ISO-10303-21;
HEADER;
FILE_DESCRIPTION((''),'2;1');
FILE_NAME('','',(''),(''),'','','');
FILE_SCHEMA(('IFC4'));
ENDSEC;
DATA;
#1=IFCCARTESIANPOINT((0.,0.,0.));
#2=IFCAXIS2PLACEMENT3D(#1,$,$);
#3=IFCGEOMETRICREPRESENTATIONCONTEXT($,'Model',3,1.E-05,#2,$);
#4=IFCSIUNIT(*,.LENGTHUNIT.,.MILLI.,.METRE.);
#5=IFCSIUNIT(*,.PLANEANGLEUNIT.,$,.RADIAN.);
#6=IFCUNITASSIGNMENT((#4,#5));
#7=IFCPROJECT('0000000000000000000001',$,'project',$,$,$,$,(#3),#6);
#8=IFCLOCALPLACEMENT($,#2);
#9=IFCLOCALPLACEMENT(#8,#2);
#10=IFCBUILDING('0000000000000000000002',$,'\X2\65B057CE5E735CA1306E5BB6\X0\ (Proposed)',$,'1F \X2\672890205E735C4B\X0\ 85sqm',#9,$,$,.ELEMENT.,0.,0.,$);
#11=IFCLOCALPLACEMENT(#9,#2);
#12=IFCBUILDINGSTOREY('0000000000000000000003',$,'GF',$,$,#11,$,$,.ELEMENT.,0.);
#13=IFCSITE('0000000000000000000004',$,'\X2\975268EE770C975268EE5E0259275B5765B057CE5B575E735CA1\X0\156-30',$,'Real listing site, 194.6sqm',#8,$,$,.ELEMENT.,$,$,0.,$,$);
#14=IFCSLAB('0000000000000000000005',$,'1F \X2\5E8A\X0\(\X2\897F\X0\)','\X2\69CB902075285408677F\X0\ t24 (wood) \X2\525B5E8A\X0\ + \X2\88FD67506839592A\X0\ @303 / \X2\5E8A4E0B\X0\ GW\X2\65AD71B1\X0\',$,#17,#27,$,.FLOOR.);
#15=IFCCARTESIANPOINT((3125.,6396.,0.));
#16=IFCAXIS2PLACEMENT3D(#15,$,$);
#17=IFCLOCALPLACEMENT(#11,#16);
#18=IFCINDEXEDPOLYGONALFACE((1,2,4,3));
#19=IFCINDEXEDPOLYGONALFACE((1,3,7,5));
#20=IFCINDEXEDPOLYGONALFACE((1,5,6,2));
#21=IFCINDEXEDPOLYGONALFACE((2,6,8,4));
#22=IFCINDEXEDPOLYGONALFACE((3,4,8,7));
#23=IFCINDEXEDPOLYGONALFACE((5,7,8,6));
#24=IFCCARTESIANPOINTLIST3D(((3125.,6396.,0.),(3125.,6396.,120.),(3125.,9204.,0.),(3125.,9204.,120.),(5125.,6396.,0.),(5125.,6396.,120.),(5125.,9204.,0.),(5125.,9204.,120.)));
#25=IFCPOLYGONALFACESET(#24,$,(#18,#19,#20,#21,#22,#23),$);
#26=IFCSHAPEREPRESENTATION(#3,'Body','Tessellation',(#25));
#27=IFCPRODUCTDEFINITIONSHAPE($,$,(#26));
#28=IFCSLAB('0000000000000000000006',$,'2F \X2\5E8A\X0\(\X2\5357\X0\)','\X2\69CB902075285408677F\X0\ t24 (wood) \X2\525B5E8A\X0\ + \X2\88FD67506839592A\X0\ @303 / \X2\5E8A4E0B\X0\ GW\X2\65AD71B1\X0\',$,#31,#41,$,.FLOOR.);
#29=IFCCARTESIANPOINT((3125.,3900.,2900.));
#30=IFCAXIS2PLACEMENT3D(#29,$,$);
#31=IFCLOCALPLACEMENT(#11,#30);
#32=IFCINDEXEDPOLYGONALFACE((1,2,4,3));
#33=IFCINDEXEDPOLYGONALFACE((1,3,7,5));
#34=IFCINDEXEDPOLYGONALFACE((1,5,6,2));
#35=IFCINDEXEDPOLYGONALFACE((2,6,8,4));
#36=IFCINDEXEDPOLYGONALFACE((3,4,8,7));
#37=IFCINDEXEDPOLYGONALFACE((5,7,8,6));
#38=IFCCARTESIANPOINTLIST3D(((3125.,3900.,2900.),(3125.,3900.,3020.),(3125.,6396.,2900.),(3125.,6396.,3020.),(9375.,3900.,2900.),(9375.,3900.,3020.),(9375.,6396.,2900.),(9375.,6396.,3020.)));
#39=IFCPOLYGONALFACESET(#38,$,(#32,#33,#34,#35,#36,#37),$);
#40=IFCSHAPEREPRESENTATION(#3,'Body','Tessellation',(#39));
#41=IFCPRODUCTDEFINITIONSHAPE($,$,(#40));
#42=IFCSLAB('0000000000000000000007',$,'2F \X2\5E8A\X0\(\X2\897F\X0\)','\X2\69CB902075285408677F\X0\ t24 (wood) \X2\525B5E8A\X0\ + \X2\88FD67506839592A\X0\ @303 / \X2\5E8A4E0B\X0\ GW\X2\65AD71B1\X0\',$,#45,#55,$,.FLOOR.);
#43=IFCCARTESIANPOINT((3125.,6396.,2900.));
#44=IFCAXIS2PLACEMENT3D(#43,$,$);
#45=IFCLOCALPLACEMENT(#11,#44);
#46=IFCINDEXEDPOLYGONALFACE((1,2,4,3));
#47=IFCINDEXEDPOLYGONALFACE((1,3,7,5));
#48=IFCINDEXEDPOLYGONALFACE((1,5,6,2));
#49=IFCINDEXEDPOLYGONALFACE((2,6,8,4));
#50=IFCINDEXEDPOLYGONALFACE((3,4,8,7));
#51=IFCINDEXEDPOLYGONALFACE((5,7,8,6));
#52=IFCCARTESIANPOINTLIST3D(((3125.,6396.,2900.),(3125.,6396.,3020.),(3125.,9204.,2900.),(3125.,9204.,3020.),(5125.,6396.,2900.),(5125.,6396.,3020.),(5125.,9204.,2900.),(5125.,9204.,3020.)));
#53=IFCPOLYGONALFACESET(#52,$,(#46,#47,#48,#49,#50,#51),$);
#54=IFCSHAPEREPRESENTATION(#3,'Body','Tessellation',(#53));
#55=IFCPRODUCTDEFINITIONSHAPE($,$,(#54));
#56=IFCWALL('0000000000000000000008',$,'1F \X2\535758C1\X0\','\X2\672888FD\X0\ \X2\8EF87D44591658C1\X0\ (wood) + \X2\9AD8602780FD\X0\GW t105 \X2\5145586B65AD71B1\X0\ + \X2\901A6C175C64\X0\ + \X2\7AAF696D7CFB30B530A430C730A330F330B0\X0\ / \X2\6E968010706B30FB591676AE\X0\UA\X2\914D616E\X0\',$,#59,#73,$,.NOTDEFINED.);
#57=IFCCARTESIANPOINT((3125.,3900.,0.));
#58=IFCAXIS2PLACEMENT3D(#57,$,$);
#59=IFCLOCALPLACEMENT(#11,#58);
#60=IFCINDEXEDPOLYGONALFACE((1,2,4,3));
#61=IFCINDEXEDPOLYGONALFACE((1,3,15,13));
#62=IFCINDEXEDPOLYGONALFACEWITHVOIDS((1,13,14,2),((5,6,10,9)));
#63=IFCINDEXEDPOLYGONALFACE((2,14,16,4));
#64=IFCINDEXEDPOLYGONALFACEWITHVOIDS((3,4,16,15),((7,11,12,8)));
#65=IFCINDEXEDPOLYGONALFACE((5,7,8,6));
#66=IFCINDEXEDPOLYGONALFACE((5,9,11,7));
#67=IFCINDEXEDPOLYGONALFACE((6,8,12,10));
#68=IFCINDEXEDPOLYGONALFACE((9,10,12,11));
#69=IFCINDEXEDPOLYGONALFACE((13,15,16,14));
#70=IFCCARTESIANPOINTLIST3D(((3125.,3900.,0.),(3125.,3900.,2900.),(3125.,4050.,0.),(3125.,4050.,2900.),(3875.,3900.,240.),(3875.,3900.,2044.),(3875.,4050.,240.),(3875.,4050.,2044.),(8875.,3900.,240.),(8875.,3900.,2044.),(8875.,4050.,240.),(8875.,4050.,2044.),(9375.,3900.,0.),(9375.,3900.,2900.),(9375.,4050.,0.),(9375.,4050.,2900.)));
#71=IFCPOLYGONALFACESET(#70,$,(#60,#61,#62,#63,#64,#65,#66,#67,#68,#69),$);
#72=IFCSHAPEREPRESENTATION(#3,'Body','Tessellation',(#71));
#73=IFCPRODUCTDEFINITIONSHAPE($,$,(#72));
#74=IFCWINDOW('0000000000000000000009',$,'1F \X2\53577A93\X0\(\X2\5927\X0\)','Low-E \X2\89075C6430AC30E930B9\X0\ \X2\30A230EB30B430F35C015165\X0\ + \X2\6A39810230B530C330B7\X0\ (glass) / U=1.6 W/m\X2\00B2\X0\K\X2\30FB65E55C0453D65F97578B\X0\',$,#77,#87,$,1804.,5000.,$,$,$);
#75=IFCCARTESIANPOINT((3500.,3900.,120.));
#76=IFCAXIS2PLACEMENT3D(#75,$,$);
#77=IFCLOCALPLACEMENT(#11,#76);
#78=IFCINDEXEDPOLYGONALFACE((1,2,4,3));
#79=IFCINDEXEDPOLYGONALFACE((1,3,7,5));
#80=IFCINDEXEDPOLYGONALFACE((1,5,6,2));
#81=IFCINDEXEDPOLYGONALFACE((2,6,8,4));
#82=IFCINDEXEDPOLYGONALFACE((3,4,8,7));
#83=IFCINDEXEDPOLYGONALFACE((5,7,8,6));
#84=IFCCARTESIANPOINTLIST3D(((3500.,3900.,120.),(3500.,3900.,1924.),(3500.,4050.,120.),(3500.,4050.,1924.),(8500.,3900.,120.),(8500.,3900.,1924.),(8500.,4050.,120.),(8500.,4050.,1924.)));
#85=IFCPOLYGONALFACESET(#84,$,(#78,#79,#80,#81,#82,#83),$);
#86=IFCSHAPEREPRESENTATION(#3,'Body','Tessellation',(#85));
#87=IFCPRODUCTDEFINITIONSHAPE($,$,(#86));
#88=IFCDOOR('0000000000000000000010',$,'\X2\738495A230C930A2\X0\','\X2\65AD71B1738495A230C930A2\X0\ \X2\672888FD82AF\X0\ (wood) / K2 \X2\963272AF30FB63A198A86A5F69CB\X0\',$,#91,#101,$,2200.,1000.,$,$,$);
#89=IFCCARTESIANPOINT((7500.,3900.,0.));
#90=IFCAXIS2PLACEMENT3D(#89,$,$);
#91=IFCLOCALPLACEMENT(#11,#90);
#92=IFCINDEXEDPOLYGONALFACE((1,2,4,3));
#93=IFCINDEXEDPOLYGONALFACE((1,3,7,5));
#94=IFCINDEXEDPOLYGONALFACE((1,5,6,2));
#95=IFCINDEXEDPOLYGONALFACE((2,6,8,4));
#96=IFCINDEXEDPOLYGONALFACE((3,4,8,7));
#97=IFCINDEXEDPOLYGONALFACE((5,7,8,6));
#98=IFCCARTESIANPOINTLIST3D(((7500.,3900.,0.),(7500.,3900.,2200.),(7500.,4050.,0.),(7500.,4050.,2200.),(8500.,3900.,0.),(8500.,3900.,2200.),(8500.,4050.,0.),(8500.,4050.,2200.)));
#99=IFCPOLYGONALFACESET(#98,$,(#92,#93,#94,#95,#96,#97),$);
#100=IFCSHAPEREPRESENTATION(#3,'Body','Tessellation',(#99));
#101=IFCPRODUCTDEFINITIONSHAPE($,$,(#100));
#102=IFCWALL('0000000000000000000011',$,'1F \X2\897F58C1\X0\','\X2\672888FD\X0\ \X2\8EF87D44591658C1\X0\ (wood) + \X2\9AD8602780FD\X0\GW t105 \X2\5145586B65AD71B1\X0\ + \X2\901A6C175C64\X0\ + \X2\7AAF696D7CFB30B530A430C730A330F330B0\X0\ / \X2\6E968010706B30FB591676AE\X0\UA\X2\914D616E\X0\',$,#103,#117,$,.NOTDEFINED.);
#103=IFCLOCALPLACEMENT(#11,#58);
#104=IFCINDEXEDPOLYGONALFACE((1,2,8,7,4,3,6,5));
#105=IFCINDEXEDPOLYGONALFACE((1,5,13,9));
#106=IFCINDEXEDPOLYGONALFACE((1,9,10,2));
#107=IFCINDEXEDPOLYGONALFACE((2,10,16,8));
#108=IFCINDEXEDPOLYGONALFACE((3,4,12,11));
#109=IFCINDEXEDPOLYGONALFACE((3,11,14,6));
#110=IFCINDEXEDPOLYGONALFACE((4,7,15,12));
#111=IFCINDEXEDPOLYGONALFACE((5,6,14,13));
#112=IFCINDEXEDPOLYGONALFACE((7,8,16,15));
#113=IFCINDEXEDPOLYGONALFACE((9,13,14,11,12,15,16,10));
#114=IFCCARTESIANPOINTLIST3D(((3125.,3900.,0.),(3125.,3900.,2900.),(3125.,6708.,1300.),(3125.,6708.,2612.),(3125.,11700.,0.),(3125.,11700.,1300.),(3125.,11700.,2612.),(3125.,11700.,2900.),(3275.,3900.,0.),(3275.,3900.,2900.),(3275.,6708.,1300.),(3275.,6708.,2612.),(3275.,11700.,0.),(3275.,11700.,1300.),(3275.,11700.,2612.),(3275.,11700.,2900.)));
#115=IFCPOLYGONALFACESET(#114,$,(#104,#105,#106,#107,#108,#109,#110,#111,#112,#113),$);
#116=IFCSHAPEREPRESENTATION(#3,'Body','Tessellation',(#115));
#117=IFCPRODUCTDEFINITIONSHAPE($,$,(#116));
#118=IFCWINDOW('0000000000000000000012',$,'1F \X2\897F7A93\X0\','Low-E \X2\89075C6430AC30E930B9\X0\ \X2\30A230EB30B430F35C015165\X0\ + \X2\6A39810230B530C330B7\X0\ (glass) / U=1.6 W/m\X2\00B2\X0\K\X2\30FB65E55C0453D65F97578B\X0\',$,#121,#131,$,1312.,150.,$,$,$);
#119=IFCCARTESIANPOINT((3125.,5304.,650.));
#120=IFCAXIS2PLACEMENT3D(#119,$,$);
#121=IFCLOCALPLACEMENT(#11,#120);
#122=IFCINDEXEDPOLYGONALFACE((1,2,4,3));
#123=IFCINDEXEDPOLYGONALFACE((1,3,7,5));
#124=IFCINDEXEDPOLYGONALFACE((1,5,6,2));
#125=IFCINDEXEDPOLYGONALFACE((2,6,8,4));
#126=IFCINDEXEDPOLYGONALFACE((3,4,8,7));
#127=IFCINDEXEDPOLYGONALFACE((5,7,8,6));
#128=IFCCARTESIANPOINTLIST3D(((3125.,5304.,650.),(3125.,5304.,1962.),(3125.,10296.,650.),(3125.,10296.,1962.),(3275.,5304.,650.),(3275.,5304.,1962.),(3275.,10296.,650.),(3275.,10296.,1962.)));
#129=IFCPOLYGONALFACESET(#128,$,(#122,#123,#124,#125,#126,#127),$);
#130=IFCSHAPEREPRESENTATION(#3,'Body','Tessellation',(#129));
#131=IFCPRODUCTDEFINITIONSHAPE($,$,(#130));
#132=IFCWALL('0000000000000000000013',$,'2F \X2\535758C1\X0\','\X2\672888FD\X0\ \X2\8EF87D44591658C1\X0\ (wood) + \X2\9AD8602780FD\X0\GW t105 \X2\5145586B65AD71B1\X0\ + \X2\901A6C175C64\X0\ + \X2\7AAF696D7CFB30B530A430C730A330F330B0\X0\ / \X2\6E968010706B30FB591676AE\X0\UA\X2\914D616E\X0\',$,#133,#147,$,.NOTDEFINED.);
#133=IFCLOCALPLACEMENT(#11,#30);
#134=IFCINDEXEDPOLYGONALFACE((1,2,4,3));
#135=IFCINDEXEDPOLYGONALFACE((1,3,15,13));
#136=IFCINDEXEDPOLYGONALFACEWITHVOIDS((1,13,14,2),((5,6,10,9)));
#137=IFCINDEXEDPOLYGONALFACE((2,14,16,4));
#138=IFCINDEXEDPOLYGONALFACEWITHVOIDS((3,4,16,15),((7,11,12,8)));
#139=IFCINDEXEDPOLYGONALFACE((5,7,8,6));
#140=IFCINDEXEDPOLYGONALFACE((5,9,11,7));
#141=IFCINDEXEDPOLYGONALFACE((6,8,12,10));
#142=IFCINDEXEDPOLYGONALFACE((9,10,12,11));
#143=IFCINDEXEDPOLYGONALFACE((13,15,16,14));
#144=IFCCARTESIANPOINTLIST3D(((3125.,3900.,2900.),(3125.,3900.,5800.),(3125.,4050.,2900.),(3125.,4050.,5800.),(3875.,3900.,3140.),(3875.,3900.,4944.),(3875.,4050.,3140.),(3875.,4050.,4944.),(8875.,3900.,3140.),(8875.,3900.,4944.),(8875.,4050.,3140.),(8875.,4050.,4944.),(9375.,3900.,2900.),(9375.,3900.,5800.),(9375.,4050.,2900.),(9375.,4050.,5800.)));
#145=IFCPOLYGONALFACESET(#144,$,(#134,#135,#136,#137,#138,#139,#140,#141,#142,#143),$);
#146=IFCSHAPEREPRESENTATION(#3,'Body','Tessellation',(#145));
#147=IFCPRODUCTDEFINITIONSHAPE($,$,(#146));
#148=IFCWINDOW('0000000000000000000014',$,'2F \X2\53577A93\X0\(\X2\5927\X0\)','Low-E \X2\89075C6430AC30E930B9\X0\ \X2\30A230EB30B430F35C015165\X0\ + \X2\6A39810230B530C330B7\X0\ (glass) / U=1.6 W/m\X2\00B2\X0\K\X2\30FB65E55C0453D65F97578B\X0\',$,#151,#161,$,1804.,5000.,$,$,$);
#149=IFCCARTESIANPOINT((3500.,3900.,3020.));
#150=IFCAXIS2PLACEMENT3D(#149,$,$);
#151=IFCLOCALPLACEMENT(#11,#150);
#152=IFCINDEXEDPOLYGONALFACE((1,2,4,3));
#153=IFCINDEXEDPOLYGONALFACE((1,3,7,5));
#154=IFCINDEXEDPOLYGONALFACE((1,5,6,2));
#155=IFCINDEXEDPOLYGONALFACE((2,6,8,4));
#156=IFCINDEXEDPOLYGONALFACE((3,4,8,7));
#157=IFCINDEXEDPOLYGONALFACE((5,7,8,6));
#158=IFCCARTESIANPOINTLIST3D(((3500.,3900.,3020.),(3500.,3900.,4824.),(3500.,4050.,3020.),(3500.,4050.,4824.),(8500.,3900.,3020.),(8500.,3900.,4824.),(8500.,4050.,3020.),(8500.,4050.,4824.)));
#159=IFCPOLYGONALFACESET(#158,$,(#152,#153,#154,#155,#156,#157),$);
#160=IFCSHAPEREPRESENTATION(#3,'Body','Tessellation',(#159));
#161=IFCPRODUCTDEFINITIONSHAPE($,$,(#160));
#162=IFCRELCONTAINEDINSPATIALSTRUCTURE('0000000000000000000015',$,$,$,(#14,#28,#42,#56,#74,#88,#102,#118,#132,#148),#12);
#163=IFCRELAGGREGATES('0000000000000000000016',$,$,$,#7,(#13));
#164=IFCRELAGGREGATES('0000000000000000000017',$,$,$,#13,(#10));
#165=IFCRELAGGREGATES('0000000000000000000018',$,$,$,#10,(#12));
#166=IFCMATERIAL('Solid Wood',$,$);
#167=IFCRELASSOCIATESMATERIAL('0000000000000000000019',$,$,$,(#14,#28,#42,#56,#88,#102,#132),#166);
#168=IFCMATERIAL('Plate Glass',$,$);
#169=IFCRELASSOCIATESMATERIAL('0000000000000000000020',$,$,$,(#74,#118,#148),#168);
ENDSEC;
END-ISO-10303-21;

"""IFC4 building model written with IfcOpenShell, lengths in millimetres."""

from ifc_helpers import new_model, si_unit, frame, frame_2d, origin, place, context, project, spatial, rectangle, extrude, material, element, fill, save


model = new_model("IFC4")

# Units and contexts
model_context = context("Model", 3, precision=1e-05, world=origin())
ifc_project = project(units=[si_unit("LENGTHUNIT", "METRE", prefix="MILLI"), si_unit("PLANEANGLEUNIT", "RADIAN")], contexts=[model_context])

# Site, building, storey
site_placement = place(None, origin())
site = spatial("IfcSite", under=ifc_project, at=site_placement, Name="青森県青森市大字新城字平岡156-30", ObjectType="Real listing site, 194.6sqm", CompositionType="ELEMENT", RefElevation=0.0)
building_placement = place(site_placement, origin())
building = spatial("IfcBuilding", under=site, at=building_placement, Name="新城平岡の家 (Proposed)", ObjectType="1F 木造平屋 85sqm", CompositionType="ELEMENT", ElevationOfRefHeight=0.0, ElevationOfTerrain=0.0)
storey_placement = place(building_placement, origin())
storey = spatial("IfcBuildingStorey", under=building, at=storey_placement, Name="GF", CompositionType="ELEMENT", Elevation=0.0)

# Slabs
ifc_material_1 = material(Name="Solid Wood")
slab_1_placement = place(storey_placement, frame((3125.0, 6396.0, 0.0)))
element("IfcSlab", 1, at=slab_1_placement, inside=storey, material=ifc_material_1, Name="1F 床(西)", Description="構造用合板 t24 (wood) 剛床 + 製材根太 @303 / 床下 GW断熱", PredefinedType="FLOOR", context=model_context, shape_type="SweptSolid", body=[
    extrude(rectangle(XDim=2000.0, YDim=2808.0, at=frame_2d((1000.0, 1404.0))), frame((3125.0, 6396.0, 0.0)), (0.0, 0.0, 1.0), 120.0),
])
slab_2_placement = place(storey_placement, frame((3125.0, 3900.0, 2900.0)))
element("IfcSlab", 2, at=slab_2_placement, inside=storey, material=ifc_material_1, Name="2F 床(南)", Description="構造用合板 t24 (wood) 剛床 + 製材根太 @303 / 床下 GW断熱", PredefinedType="FLOOR", context=model_context, shape_type="SweptSolid", body=[
    extrude(rectangle(XDim=6250.0, YDim=2496.0, at=frame_2d((3125.0, 1248.0))), frame((3125.0, 3900.0, 2900.0)), (0.0, 0.0, 1.0), 120.0),
])
slab_3_placement = place(storey_placement, frame((3125.0, 6396.0, 2900.0)))
element("IfcSlab", 3, at=slab_3_placement, inside=storey, material=ifc_material_1, Name="2F 床(西)", Description="構造用合板 t24 (wood) 剛床 + 製材根太 @303 / 床下 GW断熱", PredefinedType="FLOOR", context=model_context, shape_type="SweptSolid", body=[
    extrude(rectangle(XDim=2000.0, YDim=2808.0, at=frame_2d((1000.0, 1404.0))), frame((3125.0, 6396.0, 2900.0)), (0.0, 0.0, 1.0), 120.0),
])

# Wall, openings, window, door
wall_1_placement = place(storey_placement, frame((3125.0, 3900.0, 0.0)))
wall_1 = element("IfcWall", 4, at=wall_1_placement, inside=storey, material=ifc_material_1, Name="1F 南壁", Description="木製 軸組外壁 (wood) + 高性能GW t105 充填断熱 + 通気層 + 窯業系サイディング / 準耐火・外皮UA配慮", PredefinedType="NOTDEFINED", context=model_context, shape_type="SweptSolid", body=[
    extrude(rectangle(XDim=6250.0, YDim=150.0, at=frame_2d((3125.0, 75.0))), frame((3125.0, 3900.0, 0.0)), (0.0, 0.0, 1.0), 2900.0),
])
opening_1_placement = place(storey_placement, frame((3500.0, 3900.0, 120.0)))
opening_1 = element("IfcOpeningElement", 5, at=opening_1_placement, cuts=wall_1, PredefinedType="NOTDEFINED", context=model_context, shape_type="SweptSolid", body=[
    extrude(rectangle(XDim=5000.0, YDim=150.0, at=frame_2d((2500.0, 75.0))), frame((3500.0, 3900.0, 120.0)), (0.0, 0.0, 1.0), 1804.0),
])
opening_2_placement = place(storey_placement, frame((7500.0, 3900.0, 0.0)))
opening_2 = element("IfcOpeningElement", 6, at=opening_2_placement, cuts=wall_1, PredefinedType="NOTDEFINED", context=model_context, shape_type="SweptSolid", body=[
    extrude(rectangle(XDim=1000.0, YDim=150.0, at=frame_2d((500.0, 75.0))), frame((7500.0, 3900.0, 0.0)), (0.0, 0.0, 1.0), 2200.0),
])
ifc_material_2 = material(Name="Plate Glass")
window_1_placement = place(storey_placement, frame((3500.0, 3900.0, 120.0)))
window_1 = element("IfcWindow", 7, at=window_1_placement, inside=storey, material=ifc_material_2, Name="1F 南窓(大)", Description="Low-E 複層ガラス アルゴン封入 + 樹脂サッシ (glass) / U=1.6 W/m²K・日射取得型", OverallHeight=1804.0, OverallWidth=5000.0, context=model_context, shape_type="SweptSolid", body=[
    extrude(rectangle(XDim=5000.0, YDim=150.0, at=frame_2d((2500.0, 75.0))), frame((3500.0, 3900.0, 120.0)), (0.0, 0.0, 1.0), 1804.0),
])
fill(opening_1, window_1)
door_placement = place(storey_placement, frame((7500.0, 3900.0, 0.0)))
door = element("IfcDoor", 8, at=door_placement, inside=storey, material=ifc_material_1, Name="玄関ドア", Description="断熱玄関ドア 木製芯 (wood) / K2 防犯・採風機構", OverallHeight=2200.0, OverallWidth=1000.0, context=model_context, shape_type="SweptSolid", body=[
    extrude(rectangle(XDim=1000.0, YDim=150.0, at=frame_2d((500.0, 75.0))), frame((7500.0, 3900.0, 0.0)), (0.0, 0.0, 1.0), 2200.0),
])
fill(opening_2, door)

# Walls, openings, windows
wall_2_placement = place(storey_placement, frame((3125.0, 3900.0, 0.0)))
wall_2 = element("IfcWall", 9, at=wall_2_placement, inside=storey, material=ifc_material_1, Name="1F 西壁", Description="木製 軸組外壁 (wood) + 高性能GW t105 充填断熱 + 通気層 + 窯業系サイディング / 準耐火・外皮UA配慮", PredefinedType="NOTDEFINED", context=model_context, shape_type="SweptSolid", body=[
    extrude(rectangle(XDim=150.0, YDim=7800.0, at=frame_2d((75.0, 3900.0))), frame((3125.0, 3900.0, 0.0)), (0.0, 0.0, 1.0), 2900.0),
])
opening_3_placement = place(storey_placement, frame((3125.0, 5304.0, 650.0)))
opening_3 = element("IfcOpeningElement", 10, at=opening_3_placement, cuts=wall_2, PredefinedType="NOTDEFINED", context=model_context, shape_type="SweptSolid", body=[
    extrude(rectangle(XDim=150.0, YDim=4992.0, at=frame_2d((75.0, 2496.0))), frame((3125.0, 5304.0, 650.0)), (0.0, 0.0, 1.0), 1312.0),
])
window_2_placement = place(storey_placement, frame((3125.0, 5304.0, 650.0)))
window_2 = element("IfcWindow", 11, at=window_2_placement, inside=storey, material=ifc_material_2, Name="1F 西窓", Description="Low-E 複層ガラス アルゴン封入 + 樹脂サッシ (glass) / U=1.6 W/m²K・日射取得型", OverallHeight=1312.0, OverallWidth=150.0, context=model_context, shape_type="SweptSolid", body=[
    extrude(rectangle(XDim=150.0, YDim=4992.0, at=frame_2d((75.0, 2496.0))), frame((3125.0, 5304.0, 650.0)), (0.0, 0.0, 1.0), 1312.0),
])
fill(opening_3, window_2)
wall_3_placement = place(storey_placement, frame((3125.0, 3900.0, 2900.0)))
wall_3 = element("IfcWall", 12, at=wall_3_placement, inside=storey, material=ifc_material_1, Name="2F 南壁", Description="木製 軸組外壁 (wood) + 高性能GW t105 充填断熱 + 通気層 + 窯業系サイディング / 準耐火・外皮UA配慮", PredefinedType="NOTDEFINED", context=model_context, shape_type="SweptSolid", body=[
    extrude(rectangle(XDim=6250.0, YDim=150.0, at=frame_2d((3125.0, 75.0))), frame((3125.0, 3900.0, 2900.0)), (0.0, 0.0, 1.0), 2900.0),
])
opening_4_placement = place(storey_placement, frame((3500.0, 3900.0, 3020.0)))
opening_4 = element("IfcOpeningElement", 13, at=opening_4_placement, cuts=wall_3, PredefinedType="NOTDEFINED", context=model_context, shape_type="SweptSolid", body=[
    extrude(rectangle(XDim=5000.0, YDim=150.0, at=frame_2d((2500.0, 75.0))), frame((3500.0, 3900.0, 3020.0)), (0.0, 0.0, 1.0), 1804.0),
])
window_3_placement = place(storey_placement, frame((3500.0, 3900.0, 3020.0)))
window_3 = element("IfcWindow", 14, at=window_3_placement, inside=storey, material=ifc_material_2, Name="2F 南窓(大)", Description="Low-E 複層ガラス アルゴン封入 + 樹脂サッシ (glass) / U=1.6 W/m²K・日射取得型", OverallHeight=1804.0, OverallWidth=5000.0, context=model_context, shape_type="SweptSolid", body=[
    extrude(rectangle(XDim=5000.0, YDim=150.0, at=frame_2d((2500.0, 75.0))), frame((3500.0, 3900.0, 3020.0)), (0.0, 0.0, 1.0), 1804.0),
])
fill(opening_4, window_3)

save(model, "model.ifc")
